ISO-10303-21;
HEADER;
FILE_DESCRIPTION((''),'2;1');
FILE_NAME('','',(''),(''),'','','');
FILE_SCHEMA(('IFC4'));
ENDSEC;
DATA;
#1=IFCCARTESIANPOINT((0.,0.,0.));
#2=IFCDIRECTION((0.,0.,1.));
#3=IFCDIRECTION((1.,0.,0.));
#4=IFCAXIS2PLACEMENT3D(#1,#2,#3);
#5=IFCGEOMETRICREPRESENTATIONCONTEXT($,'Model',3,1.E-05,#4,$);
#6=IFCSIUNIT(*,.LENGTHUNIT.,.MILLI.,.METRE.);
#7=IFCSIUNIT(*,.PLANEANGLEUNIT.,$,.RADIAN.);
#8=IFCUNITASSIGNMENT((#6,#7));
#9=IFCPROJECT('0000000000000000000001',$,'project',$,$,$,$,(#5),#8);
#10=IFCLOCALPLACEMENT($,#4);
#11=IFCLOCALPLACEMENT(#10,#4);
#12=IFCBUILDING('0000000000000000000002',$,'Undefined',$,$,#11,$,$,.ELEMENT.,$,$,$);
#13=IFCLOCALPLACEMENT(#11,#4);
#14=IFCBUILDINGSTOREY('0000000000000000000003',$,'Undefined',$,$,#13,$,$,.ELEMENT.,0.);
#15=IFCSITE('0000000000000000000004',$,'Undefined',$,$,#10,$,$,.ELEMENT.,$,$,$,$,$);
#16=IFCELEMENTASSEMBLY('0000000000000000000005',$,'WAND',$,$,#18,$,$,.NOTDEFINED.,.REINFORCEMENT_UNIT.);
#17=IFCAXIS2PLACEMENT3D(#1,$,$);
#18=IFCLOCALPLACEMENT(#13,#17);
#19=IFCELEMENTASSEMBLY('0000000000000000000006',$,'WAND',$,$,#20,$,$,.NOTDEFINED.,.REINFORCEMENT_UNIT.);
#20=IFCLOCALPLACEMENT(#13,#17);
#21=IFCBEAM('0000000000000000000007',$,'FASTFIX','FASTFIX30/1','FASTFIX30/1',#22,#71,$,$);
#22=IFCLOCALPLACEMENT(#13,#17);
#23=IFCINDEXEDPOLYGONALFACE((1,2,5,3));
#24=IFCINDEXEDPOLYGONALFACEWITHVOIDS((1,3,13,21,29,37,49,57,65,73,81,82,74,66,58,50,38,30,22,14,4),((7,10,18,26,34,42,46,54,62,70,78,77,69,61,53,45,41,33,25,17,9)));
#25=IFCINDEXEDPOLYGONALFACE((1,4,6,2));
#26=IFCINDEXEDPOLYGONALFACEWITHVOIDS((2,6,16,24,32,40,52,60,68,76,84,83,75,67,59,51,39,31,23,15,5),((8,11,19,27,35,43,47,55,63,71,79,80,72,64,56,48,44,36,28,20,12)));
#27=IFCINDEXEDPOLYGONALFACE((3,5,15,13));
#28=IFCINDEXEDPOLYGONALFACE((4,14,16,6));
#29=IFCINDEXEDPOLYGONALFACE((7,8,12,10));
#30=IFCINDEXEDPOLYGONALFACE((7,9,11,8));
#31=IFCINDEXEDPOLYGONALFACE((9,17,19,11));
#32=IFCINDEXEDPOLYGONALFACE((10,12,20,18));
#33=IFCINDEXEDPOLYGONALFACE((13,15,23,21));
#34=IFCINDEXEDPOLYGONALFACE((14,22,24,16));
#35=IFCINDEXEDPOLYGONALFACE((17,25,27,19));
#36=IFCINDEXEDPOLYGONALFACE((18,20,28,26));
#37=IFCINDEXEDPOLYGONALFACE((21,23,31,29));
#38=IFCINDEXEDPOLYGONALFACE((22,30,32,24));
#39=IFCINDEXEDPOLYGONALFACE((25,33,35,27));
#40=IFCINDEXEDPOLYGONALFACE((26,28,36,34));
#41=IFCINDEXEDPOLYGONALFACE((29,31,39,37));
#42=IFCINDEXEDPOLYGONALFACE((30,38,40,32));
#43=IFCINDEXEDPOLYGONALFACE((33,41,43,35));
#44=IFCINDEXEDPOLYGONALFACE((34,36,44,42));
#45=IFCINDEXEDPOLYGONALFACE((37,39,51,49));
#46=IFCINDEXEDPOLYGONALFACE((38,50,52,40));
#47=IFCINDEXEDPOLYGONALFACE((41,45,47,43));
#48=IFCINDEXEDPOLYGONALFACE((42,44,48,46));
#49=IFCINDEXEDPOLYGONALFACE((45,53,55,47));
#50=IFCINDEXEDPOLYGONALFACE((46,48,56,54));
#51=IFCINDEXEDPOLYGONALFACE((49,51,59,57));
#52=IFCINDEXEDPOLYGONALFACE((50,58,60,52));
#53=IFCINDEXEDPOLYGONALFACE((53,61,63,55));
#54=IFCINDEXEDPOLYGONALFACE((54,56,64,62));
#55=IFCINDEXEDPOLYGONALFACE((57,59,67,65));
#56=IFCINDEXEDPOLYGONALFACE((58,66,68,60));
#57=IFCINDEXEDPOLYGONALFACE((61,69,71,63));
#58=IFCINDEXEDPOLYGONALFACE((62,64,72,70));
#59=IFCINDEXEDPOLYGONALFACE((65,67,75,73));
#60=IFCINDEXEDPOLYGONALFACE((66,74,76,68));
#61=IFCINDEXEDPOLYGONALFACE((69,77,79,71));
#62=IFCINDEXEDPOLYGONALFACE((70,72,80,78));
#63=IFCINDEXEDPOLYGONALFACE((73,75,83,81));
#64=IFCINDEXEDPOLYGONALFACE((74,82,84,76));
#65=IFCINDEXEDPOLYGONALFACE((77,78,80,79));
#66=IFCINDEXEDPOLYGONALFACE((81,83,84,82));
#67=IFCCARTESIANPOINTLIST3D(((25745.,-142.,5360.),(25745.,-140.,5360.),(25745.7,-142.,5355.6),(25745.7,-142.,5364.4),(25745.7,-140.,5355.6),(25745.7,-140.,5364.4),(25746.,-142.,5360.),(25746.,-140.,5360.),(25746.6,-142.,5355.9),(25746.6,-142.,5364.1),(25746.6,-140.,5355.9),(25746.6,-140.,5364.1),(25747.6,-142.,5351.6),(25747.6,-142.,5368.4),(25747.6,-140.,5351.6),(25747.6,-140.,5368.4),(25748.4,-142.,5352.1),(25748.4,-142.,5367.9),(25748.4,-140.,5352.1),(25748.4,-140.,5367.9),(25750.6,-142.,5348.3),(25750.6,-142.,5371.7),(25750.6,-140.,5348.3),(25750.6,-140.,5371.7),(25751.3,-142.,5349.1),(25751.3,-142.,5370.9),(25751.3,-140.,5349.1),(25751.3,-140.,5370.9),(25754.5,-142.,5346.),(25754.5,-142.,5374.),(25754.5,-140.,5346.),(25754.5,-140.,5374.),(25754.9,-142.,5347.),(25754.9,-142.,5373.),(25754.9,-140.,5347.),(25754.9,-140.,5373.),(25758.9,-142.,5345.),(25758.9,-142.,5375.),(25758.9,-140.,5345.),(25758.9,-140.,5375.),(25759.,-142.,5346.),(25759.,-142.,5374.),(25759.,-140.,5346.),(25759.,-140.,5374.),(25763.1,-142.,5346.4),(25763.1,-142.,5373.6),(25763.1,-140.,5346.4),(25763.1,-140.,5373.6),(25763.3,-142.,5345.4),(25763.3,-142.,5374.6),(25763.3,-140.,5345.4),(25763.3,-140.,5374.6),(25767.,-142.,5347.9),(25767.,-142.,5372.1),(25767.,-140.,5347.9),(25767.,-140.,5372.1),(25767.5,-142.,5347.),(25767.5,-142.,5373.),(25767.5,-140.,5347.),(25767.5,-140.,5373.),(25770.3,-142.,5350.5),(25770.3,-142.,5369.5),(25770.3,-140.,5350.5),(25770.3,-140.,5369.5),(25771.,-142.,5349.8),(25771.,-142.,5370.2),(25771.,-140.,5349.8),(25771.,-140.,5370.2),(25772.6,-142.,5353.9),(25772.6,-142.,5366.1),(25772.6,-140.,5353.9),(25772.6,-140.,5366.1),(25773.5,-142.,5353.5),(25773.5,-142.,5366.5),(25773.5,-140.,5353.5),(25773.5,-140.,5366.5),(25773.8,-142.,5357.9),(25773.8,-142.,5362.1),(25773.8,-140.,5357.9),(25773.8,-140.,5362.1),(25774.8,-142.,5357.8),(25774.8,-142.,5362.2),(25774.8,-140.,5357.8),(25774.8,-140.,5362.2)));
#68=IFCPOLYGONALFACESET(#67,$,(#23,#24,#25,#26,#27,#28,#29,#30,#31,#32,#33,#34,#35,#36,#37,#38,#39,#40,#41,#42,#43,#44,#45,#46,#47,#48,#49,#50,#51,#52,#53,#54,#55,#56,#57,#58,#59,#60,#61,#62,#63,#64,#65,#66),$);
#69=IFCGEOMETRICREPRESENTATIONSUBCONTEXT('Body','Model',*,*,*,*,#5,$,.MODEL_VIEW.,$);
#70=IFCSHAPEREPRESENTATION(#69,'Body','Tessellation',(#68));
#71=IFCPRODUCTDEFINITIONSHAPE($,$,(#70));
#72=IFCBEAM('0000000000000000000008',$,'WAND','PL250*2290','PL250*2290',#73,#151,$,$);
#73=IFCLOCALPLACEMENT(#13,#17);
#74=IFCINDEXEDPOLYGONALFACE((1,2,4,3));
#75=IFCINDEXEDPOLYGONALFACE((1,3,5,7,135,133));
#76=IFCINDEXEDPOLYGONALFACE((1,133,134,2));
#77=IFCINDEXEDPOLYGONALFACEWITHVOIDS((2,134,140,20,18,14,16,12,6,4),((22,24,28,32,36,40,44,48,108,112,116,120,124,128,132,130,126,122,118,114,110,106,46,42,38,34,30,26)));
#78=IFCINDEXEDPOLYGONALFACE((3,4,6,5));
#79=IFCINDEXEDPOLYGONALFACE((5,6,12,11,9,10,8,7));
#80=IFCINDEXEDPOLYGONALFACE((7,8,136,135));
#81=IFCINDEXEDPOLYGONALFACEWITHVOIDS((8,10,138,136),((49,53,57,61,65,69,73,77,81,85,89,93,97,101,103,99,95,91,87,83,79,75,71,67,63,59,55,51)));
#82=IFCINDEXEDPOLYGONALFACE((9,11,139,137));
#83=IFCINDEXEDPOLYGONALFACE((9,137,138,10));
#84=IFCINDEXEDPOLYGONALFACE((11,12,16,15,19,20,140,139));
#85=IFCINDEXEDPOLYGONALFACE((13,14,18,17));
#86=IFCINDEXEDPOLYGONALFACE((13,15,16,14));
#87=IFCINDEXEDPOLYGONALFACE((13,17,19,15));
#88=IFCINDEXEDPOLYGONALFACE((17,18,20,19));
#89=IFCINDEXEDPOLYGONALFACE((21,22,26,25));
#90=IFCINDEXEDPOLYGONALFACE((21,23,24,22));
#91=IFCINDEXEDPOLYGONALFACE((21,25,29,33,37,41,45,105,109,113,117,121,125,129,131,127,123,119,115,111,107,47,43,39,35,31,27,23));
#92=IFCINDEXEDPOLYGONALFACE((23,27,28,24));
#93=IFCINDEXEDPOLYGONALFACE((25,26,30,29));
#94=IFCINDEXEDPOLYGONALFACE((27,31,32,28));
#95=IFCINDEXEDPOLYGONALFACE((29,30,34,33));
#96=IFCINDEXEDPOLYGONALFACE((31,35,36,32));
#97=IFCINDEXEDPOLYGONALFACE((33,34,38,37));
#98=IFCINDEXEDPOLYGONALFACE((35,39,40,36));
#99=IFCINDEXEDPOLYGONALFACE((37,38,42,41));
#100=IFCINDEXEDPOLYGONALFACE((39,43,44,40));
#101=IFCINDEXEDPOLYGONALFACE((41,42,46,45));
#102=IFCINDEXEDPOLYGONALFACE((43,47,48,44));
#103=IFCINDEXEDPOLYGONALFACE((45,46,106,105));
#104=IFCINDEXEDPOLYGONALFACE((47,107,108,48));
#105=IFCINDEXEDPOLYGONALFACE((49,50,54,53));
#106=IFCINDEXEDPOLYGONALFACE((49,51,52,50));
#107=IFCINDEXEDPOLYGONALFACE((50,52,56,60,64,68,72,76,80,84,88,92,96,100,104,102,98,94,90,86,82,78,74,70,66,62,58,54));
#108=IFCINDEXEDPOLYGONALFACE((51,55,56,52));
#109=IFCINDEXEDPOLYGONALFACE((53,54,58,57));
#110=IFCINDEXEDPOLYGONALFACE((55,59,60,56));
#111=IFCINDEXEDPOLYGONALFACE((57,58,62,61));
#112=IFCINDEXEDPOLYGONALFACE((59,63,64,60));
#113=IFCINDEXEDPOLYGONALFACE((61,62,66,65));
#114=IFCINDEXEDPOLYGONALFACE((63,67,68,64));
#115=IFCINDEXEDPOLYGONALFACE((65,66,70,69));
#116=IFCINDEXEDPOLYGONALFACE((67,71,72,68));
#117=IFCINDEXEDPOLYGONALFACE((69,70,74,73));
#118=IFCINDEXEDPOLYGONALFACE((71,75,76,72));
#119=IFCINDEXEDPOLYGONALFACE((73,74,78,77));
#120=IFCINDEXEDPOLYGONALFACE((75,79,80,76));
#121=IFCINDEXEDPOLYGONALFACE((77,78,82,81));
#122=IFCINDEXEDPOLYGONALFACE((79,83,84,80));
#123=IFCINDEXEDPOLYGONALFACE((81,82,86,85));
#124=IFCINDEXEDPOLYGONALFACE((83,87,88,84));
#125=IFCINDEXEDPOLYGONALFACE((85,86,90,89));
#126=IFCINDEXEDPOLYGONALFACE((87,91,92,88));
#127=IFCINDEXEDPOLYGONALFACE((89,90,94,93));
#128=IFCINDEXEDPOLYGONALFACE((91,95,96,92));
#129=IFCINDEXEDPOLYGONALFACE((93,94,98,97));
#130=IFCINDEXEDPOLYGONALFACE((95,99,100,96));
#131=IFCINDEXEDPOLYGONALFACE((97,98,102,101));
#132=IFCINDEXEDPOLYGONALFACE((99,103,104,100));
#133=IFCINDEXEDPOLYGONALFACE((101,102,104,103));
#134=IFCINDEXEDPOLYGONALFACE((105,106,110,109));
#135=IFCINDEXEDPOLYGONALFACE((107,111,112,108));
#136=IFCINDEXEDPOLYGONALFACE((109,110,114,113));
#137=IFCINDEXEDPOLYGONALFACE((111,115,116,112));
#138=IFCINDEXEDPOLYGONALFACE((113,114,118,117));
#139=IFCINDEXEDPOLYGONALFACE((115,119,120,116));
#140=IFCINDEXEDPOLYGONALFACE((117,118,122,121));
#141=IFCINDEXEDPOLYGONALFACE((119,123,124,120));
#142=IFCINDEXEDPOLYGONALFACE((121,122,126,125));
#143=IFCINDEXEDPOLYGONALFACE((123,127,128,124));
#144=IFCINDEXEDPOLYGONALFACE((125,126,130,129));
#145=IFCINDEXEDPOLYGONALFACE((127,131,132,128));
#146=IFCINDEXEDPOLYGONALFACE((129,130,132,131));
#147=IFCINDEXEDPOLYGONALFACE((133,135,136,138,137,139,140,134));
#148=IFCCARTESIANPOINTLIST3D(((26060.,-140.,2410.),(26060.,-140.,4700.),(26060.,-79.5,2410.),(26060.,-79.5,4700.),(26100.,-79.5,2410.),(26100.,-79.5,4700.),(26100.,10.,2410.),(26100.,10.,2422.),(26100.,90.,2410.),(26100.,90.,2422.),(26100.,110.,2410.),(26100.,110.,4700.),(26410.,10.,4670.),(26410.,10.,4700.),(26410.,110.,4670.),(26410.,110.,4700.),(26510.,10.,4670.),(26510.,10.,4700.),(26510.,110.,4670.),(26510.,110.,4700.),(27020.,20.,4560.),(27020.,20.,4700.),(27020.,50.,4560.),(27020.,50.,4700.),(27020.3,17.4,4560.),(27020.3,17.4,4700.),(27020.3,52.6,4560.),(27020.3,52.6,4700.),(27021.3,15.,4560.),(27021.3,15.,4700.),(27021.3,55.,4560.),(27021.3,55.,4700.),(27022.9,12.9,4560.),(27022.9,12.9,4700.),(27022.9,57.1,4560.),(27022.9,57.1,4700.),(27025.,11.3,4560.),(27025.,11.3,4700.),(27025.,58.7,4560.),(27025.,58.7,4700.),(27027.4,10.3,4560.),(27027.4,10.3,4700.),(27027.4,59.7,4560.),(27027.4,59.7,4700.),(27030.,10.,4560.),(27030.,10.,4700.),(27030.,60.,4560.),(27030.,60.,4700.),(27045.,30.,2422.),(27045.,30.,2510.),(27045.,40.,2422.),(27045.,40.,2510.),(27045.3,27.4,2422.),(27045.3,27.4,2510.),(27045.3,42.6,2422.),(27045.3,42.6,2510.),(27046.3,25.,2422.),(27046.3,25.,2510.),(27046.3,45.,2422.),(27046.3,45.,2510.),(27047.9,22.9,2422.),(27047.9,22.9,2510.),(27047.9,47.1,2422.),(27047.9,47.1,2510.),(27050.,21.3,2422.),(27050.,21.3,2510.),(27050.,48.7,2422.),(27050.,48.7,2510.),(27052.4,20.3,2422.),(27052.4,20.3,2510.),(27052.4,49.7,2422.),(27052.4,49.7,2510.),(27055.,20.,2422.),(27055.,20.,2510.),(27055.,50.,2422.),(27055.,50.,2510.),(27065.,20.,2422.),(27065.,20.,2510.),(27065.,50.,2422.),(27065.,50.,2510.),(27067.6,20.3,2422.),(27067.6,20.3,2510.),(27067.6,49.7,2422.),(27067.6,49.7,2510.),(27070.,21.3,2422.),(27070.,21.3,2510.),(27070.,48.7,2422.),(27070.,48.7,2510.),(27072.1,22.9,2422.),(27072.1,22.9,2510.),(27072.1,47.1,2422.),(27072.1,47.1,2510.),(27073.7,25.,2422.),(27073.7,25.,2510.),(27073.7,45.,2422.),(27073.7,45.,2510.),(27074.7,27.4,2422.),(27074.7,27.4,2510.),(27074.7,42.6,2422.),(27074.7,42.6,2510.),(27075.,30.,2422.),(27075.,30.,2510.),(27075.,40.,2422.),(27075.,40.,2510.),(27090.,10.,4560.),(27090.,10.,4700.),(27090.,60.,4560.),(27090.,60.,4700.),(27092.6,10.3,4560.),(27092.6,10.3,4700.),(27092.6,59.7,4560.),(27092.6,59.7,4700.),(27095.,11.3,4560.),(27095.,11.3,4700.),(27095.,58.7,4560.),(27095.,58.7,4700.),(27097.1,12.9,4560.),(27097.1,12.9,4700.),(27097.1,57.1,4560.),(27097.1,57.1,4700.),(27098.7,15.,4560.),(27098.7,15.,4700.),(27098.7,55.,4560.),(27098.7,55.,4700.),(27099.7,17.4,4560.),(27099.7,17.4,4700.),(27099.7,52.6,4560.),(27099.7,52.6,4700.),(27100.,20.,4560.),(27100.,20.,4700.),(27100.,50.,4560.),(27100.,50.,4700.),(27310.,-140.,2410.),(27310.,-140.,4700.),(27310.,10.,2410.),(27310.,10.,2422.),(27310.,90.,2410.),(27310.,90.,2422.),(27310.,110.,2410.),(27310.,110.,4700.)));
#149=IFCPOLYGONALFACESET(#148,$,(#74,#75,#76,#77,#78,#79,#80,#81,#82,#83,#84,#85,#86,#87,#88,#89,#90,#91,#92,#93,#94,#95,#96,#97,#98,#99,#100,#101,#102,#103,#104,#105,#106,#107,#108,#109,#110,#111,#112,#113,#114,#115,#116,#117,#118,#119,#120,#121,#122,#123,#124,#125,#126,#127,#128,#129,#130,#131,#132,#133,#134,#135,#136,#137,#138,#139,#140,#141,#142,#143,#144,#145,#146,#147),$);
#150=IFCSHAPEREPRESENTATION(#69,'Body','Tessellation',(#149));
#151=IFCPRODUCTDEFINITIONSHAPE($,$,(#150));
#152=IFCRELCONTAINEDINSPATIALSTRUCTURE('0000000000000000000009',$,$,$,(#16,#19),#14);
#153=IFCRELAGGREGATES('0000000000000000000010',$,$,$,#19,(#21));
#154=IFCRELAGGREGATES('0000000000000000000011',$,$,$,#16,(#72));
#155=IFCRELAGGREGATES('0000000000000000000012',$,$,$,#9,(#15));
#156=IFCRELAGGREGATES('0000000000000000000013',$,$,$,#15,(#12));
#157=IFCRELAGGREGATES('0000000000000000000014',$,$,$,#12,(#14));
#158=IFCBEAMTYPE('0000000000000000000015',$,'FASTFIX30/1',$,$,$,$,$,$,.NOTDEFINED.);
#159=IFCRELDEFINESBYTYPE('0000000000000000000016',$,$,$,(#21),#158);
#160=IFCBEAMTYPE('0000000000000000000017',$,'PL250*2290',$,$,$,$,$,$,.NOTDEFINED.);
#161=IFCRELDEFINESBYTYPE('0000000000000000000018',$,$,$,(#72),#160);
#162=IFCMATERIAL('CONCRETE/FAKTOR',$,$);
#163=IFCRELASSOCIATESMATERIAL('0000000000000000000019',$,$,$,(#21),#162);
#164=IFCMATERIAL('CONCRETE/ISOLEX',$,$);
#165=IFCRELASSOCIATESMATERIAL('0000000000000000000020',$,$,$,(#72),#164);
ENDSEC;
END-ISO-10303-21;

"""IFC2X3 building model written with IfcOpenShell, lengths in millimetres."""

from ifc_helpers import new_model, si_unit, frame, frame_2d, origin_with_axes, place, context, subcontext, project, spatial, polyline, circle_curve, parameter, trimmed, segment, composite_curve, rectangle, hollow_circle, outline, extrude, boolean, material, type_object, element, aggregate, save


model = new_model("IFC2X3")

# Units and contexts
model_context = context("Model", 3, precision=1e-05, world=origin_with_axes())
body_context = subcontext(model_context, "Body", "Model", "MODEL_VIEW")
ifc_project = project(units=[si_unit("LENGTHUNIT", "METRE", prefix="MILLI"), si_unit("PLANEANGLEUNIT", "RADIAN")], contexts=[model_context])

# Site, building, storey
site_placement = place(None, origin_with_axes())
site = spatial("IfcSite", under=ifc_project, at=site_placement, Name="Undefined", CompositionType="ELEMENT")
building_placement = place(site_placement, origin_with_axes())
building = spatial("IfcBuilding", under=site, at=building_placement, Name="Undefined", CompositionType="ELEMENT")
storey_placement = place(building_placement, origin_with_axes())
storey = spatial("IfcBuildingStorey", under=building, at=storey_placement, Name="Undefined", CompositionType="ELEMENT", Elevation=0.0)

# Shared definitions
ifc_material_1 = material(Name="CONCRETE/FAKTOR")

# Element assemblies
assembly_1_placement = place(storey_placement, origin_with_axes())
assembly_1 = element("IfcElementAssembly", 1, at=assembly_1_placement, inside=storey, Name="WAND", AssemblyPlace="NOTDEFINED", PredefinedType="REINFORCEMENT_UNIT")
ifc_material_2 = material(Name="CONCRETE/ISOLEX")
assembly_2_placement = place(storey_placement, origin_with_axes())
assembly_2 = element("IfcElementAssembly", 2, at=assembly_2_placement, inside=storey, Name="WAND", AssemblyPlace="NOTDEFINED", PredefinedType="REINFORCEMENT_UNIT")

# Beams
beam_type_1 = type_object("IfcBeamType", Name="FASTFIX30/1", PredefinedType="NOTDEFINED")
beam_1_placement = place(assembly_2_placement, frame((25760.0, -140.0, 5360.0), z_axis=(0.0, 0.0, 1.0), x_axis=(0.0, -1.0, 0.0)))
beam_1 = element("IfcBeam", 3, at=beam_1_placement, type_object=beam_type_1, material=ifc_material_1, Name="FASTFIX", Description="FASTFIX30/1", ObjectType="FASTFIX30/1", context=body_context, shape_type="SweptSolid", body=[
    extrude(hollow_circle(Radius=15.0, WallThickness=1.0, at=frame_2d((0.0, 0.0), x_axis=(1.0, 0.0))), frame((2.0, 0.0, 0.0), z_axis=(-1.0, 0.0, 0.0), x_axis=(0.0, -1.0, 0.0)), (0.0, 0.0, 1.0), 2.0),
])
aggregate(assembly_2, [beam_1])
beam_type_2 = type_object("IfcBeamType", Name="PL250*2290", PredefinedType="NOTDEFINED")
beam_2_placement = place(assembly_1_placement, frame((26060.0, -15.0, 3555.0), z_axis=(0.0, 0.0, 1.0), x_axis=(1.0, 0.0, 0.0)))
beam_2 = element("IfcBeam", 4, at=beam_2_placement, type_object=beam_type_2, material=ifc_material_2, Name="WAND", Description="PL250*2290", ObjectType="PL250*2290", context=body_context, shape_type="CSG", body=[
    boolean("DIFFERENCE", boolean("DIFFERENCE", boolean("DIFFERENCE", boolean("DIFFERENCE", boolean("DIFFERENCE", extrude(rectangle(XDim=250.0, YDim=2290.0, at=frame_2d((0.0, 0.0), x_axis=(1.0, 0.0))), frame((1250.0, 0.0, 0.0), z_axis=(-1.0, 0.0, 0.0), x_axis=(0.0, -1.0, 0.0)), (0.0, 0.0, 1.0), 1250.0), extrude(outline(composite_curve([segment(trimmed(circle_curve(frame_2d((10.0, 10.0), x_axis=(-1.0, 0.0)), 10.0), [parameter(0.0)], [parameter(1.570796)], True, "PARAMETER"), True, "CONTINUOUS"), segment(polyline([(10.0, 0.0), (40.0, 0.0)]), True, "CONTINUOUS"), segment(trimmed(circle_curve(frame_2d((40.0, 10.0), x_axis=(0.0, -1.0)), 10.0), [parameter(0.0)], [parameter(1.570796)], True, "PARAMETER"), True, "CONTINUOUS"), segment(polyline([(50.0, 10.0), (50.0, 70.0)]), True, "CONTINUOUS"), segment(trimmed(circle_curve(frame_2d((40.0, 70.0), x_axis=(1.0, 0.0)), 10.0), [parameter(0.0)], [parameter(1.570796)], True, "PARAMETER"), True, "CONTINUOUS"), segment(polyline([(40.0, 80.0), (10.0, 80.0)]), True, "CONTINUOUS"), segment(trimmed(circle_curve(frame_2d((10.0, 70.0), x_axis=(0.0, 1.0)), 10.0), [parameter(0.0)], [parameter(1.570796)], True, "PARAMETER"), True, "CONTINUOUS"), segment(polyline([(0.0, 70.0), (0.0, 10.0)]), True, "CONTINUOUS")], self_intersect=True)), frame((960.0, 75.0, 1005.0), z_axis=(0.0, 0.0, 1.0), x_axis=(0.0, -1.0, 0.0)), (0.0, 0.0, 1.0), 150.0)), extrude(rectangle(XDim=40.0, YDim=190.0, at=frame_2d((0.0, 0.0), x_axis=(1.0, 0.0))), frame((20.0, 30.5, 1145.0), z_axis=(0.0, 0.0, -1.0), x_axis=(1.0, 0.0, 0.0)), (0.0, 0.0, 1.0), 2290.0)), extrude(outline(composite_curve([segment(trimmed(circle_curve(frame_2d((10.0, 10.0), x_axis=(-1.0, 0.0)), 10.0), [parameter(0.0)], [parameter(1.570796)], True, "PARAMETER"), True, "CONTINUOUS"), segment(polyline([(10.0, 0.0), (20.0, 0.0)]), True, "CONTINUOUS"), segment(trimmed(circle_curve(frame_2d((20.0, 10.0), x_axis=(0.0, -1.0)), 10.0), [parameter(0.0)], [parameter(1.570796)], True, "PARAMETER"), True, "CONTINUOUS"), segment(polyline([(30.0, 10.0), (30.0, 20.0)]), True, "CONTINUOUS"), segment(trimmed(circle_curve(frame_2d((20.0, 20.0), x_axis=(1.0, 0.0)), 10.0), [parameter(0.0)], [parameter(1.570796)], True, "PARAMETER"), True, "CONTINUOUS"), segment(polyline([(20.0, 30.0), (10.0, 30.0)]), True, "CONTINUOUS"), segment(trimmed(circle_curve(frame_2d((10.0, 20.0), x_axis=(0.0, 1.0)), 10.0), [parameter(0.0)], [parameter(1.570796)], True, "PARAMETER"), True, "CONTINUOUS"), segment(polyline([(0.0, 20.0), (0.0, 10.0)]), True, "CONTINUOUS")], self_intersect=True)), frame((985.0, 65.0, -1145.0), z_axis=(0.0, 0.0, 1.0), x_axis=(0.0, -1.0, 0.0)), (0.0, 0.0, 1.0), 100.0)), extrude(rectangle(XDim=100.0, YDim=100.0, at=frame_2d((0.0, 0.0), x_axis=(1.0, 0.0))), frame((400.0, 75.0, 1115.0), z_axis=(0.0, 0.0, 1.0), x_axis=(-1.0, 0.0, 0.0)), (0.0, 0.0, 1.0), 30.0)), extrude(rectangle(XDim=12.0, YDim=80.0, at=frame_2d((0.0, 0.0), x_axis=(1.0, 0.0))), frame((1250.0, 65.0, -1139.0), z_axis=(-1.0, 0.0, 0.0), x_axis=(0.0, 0.0, -1.0)), (0.0, 0.0, 1.0), 1250.0)),
])
aggregate(assembly_1, [beam_2])

save(model, "model.ifc")
